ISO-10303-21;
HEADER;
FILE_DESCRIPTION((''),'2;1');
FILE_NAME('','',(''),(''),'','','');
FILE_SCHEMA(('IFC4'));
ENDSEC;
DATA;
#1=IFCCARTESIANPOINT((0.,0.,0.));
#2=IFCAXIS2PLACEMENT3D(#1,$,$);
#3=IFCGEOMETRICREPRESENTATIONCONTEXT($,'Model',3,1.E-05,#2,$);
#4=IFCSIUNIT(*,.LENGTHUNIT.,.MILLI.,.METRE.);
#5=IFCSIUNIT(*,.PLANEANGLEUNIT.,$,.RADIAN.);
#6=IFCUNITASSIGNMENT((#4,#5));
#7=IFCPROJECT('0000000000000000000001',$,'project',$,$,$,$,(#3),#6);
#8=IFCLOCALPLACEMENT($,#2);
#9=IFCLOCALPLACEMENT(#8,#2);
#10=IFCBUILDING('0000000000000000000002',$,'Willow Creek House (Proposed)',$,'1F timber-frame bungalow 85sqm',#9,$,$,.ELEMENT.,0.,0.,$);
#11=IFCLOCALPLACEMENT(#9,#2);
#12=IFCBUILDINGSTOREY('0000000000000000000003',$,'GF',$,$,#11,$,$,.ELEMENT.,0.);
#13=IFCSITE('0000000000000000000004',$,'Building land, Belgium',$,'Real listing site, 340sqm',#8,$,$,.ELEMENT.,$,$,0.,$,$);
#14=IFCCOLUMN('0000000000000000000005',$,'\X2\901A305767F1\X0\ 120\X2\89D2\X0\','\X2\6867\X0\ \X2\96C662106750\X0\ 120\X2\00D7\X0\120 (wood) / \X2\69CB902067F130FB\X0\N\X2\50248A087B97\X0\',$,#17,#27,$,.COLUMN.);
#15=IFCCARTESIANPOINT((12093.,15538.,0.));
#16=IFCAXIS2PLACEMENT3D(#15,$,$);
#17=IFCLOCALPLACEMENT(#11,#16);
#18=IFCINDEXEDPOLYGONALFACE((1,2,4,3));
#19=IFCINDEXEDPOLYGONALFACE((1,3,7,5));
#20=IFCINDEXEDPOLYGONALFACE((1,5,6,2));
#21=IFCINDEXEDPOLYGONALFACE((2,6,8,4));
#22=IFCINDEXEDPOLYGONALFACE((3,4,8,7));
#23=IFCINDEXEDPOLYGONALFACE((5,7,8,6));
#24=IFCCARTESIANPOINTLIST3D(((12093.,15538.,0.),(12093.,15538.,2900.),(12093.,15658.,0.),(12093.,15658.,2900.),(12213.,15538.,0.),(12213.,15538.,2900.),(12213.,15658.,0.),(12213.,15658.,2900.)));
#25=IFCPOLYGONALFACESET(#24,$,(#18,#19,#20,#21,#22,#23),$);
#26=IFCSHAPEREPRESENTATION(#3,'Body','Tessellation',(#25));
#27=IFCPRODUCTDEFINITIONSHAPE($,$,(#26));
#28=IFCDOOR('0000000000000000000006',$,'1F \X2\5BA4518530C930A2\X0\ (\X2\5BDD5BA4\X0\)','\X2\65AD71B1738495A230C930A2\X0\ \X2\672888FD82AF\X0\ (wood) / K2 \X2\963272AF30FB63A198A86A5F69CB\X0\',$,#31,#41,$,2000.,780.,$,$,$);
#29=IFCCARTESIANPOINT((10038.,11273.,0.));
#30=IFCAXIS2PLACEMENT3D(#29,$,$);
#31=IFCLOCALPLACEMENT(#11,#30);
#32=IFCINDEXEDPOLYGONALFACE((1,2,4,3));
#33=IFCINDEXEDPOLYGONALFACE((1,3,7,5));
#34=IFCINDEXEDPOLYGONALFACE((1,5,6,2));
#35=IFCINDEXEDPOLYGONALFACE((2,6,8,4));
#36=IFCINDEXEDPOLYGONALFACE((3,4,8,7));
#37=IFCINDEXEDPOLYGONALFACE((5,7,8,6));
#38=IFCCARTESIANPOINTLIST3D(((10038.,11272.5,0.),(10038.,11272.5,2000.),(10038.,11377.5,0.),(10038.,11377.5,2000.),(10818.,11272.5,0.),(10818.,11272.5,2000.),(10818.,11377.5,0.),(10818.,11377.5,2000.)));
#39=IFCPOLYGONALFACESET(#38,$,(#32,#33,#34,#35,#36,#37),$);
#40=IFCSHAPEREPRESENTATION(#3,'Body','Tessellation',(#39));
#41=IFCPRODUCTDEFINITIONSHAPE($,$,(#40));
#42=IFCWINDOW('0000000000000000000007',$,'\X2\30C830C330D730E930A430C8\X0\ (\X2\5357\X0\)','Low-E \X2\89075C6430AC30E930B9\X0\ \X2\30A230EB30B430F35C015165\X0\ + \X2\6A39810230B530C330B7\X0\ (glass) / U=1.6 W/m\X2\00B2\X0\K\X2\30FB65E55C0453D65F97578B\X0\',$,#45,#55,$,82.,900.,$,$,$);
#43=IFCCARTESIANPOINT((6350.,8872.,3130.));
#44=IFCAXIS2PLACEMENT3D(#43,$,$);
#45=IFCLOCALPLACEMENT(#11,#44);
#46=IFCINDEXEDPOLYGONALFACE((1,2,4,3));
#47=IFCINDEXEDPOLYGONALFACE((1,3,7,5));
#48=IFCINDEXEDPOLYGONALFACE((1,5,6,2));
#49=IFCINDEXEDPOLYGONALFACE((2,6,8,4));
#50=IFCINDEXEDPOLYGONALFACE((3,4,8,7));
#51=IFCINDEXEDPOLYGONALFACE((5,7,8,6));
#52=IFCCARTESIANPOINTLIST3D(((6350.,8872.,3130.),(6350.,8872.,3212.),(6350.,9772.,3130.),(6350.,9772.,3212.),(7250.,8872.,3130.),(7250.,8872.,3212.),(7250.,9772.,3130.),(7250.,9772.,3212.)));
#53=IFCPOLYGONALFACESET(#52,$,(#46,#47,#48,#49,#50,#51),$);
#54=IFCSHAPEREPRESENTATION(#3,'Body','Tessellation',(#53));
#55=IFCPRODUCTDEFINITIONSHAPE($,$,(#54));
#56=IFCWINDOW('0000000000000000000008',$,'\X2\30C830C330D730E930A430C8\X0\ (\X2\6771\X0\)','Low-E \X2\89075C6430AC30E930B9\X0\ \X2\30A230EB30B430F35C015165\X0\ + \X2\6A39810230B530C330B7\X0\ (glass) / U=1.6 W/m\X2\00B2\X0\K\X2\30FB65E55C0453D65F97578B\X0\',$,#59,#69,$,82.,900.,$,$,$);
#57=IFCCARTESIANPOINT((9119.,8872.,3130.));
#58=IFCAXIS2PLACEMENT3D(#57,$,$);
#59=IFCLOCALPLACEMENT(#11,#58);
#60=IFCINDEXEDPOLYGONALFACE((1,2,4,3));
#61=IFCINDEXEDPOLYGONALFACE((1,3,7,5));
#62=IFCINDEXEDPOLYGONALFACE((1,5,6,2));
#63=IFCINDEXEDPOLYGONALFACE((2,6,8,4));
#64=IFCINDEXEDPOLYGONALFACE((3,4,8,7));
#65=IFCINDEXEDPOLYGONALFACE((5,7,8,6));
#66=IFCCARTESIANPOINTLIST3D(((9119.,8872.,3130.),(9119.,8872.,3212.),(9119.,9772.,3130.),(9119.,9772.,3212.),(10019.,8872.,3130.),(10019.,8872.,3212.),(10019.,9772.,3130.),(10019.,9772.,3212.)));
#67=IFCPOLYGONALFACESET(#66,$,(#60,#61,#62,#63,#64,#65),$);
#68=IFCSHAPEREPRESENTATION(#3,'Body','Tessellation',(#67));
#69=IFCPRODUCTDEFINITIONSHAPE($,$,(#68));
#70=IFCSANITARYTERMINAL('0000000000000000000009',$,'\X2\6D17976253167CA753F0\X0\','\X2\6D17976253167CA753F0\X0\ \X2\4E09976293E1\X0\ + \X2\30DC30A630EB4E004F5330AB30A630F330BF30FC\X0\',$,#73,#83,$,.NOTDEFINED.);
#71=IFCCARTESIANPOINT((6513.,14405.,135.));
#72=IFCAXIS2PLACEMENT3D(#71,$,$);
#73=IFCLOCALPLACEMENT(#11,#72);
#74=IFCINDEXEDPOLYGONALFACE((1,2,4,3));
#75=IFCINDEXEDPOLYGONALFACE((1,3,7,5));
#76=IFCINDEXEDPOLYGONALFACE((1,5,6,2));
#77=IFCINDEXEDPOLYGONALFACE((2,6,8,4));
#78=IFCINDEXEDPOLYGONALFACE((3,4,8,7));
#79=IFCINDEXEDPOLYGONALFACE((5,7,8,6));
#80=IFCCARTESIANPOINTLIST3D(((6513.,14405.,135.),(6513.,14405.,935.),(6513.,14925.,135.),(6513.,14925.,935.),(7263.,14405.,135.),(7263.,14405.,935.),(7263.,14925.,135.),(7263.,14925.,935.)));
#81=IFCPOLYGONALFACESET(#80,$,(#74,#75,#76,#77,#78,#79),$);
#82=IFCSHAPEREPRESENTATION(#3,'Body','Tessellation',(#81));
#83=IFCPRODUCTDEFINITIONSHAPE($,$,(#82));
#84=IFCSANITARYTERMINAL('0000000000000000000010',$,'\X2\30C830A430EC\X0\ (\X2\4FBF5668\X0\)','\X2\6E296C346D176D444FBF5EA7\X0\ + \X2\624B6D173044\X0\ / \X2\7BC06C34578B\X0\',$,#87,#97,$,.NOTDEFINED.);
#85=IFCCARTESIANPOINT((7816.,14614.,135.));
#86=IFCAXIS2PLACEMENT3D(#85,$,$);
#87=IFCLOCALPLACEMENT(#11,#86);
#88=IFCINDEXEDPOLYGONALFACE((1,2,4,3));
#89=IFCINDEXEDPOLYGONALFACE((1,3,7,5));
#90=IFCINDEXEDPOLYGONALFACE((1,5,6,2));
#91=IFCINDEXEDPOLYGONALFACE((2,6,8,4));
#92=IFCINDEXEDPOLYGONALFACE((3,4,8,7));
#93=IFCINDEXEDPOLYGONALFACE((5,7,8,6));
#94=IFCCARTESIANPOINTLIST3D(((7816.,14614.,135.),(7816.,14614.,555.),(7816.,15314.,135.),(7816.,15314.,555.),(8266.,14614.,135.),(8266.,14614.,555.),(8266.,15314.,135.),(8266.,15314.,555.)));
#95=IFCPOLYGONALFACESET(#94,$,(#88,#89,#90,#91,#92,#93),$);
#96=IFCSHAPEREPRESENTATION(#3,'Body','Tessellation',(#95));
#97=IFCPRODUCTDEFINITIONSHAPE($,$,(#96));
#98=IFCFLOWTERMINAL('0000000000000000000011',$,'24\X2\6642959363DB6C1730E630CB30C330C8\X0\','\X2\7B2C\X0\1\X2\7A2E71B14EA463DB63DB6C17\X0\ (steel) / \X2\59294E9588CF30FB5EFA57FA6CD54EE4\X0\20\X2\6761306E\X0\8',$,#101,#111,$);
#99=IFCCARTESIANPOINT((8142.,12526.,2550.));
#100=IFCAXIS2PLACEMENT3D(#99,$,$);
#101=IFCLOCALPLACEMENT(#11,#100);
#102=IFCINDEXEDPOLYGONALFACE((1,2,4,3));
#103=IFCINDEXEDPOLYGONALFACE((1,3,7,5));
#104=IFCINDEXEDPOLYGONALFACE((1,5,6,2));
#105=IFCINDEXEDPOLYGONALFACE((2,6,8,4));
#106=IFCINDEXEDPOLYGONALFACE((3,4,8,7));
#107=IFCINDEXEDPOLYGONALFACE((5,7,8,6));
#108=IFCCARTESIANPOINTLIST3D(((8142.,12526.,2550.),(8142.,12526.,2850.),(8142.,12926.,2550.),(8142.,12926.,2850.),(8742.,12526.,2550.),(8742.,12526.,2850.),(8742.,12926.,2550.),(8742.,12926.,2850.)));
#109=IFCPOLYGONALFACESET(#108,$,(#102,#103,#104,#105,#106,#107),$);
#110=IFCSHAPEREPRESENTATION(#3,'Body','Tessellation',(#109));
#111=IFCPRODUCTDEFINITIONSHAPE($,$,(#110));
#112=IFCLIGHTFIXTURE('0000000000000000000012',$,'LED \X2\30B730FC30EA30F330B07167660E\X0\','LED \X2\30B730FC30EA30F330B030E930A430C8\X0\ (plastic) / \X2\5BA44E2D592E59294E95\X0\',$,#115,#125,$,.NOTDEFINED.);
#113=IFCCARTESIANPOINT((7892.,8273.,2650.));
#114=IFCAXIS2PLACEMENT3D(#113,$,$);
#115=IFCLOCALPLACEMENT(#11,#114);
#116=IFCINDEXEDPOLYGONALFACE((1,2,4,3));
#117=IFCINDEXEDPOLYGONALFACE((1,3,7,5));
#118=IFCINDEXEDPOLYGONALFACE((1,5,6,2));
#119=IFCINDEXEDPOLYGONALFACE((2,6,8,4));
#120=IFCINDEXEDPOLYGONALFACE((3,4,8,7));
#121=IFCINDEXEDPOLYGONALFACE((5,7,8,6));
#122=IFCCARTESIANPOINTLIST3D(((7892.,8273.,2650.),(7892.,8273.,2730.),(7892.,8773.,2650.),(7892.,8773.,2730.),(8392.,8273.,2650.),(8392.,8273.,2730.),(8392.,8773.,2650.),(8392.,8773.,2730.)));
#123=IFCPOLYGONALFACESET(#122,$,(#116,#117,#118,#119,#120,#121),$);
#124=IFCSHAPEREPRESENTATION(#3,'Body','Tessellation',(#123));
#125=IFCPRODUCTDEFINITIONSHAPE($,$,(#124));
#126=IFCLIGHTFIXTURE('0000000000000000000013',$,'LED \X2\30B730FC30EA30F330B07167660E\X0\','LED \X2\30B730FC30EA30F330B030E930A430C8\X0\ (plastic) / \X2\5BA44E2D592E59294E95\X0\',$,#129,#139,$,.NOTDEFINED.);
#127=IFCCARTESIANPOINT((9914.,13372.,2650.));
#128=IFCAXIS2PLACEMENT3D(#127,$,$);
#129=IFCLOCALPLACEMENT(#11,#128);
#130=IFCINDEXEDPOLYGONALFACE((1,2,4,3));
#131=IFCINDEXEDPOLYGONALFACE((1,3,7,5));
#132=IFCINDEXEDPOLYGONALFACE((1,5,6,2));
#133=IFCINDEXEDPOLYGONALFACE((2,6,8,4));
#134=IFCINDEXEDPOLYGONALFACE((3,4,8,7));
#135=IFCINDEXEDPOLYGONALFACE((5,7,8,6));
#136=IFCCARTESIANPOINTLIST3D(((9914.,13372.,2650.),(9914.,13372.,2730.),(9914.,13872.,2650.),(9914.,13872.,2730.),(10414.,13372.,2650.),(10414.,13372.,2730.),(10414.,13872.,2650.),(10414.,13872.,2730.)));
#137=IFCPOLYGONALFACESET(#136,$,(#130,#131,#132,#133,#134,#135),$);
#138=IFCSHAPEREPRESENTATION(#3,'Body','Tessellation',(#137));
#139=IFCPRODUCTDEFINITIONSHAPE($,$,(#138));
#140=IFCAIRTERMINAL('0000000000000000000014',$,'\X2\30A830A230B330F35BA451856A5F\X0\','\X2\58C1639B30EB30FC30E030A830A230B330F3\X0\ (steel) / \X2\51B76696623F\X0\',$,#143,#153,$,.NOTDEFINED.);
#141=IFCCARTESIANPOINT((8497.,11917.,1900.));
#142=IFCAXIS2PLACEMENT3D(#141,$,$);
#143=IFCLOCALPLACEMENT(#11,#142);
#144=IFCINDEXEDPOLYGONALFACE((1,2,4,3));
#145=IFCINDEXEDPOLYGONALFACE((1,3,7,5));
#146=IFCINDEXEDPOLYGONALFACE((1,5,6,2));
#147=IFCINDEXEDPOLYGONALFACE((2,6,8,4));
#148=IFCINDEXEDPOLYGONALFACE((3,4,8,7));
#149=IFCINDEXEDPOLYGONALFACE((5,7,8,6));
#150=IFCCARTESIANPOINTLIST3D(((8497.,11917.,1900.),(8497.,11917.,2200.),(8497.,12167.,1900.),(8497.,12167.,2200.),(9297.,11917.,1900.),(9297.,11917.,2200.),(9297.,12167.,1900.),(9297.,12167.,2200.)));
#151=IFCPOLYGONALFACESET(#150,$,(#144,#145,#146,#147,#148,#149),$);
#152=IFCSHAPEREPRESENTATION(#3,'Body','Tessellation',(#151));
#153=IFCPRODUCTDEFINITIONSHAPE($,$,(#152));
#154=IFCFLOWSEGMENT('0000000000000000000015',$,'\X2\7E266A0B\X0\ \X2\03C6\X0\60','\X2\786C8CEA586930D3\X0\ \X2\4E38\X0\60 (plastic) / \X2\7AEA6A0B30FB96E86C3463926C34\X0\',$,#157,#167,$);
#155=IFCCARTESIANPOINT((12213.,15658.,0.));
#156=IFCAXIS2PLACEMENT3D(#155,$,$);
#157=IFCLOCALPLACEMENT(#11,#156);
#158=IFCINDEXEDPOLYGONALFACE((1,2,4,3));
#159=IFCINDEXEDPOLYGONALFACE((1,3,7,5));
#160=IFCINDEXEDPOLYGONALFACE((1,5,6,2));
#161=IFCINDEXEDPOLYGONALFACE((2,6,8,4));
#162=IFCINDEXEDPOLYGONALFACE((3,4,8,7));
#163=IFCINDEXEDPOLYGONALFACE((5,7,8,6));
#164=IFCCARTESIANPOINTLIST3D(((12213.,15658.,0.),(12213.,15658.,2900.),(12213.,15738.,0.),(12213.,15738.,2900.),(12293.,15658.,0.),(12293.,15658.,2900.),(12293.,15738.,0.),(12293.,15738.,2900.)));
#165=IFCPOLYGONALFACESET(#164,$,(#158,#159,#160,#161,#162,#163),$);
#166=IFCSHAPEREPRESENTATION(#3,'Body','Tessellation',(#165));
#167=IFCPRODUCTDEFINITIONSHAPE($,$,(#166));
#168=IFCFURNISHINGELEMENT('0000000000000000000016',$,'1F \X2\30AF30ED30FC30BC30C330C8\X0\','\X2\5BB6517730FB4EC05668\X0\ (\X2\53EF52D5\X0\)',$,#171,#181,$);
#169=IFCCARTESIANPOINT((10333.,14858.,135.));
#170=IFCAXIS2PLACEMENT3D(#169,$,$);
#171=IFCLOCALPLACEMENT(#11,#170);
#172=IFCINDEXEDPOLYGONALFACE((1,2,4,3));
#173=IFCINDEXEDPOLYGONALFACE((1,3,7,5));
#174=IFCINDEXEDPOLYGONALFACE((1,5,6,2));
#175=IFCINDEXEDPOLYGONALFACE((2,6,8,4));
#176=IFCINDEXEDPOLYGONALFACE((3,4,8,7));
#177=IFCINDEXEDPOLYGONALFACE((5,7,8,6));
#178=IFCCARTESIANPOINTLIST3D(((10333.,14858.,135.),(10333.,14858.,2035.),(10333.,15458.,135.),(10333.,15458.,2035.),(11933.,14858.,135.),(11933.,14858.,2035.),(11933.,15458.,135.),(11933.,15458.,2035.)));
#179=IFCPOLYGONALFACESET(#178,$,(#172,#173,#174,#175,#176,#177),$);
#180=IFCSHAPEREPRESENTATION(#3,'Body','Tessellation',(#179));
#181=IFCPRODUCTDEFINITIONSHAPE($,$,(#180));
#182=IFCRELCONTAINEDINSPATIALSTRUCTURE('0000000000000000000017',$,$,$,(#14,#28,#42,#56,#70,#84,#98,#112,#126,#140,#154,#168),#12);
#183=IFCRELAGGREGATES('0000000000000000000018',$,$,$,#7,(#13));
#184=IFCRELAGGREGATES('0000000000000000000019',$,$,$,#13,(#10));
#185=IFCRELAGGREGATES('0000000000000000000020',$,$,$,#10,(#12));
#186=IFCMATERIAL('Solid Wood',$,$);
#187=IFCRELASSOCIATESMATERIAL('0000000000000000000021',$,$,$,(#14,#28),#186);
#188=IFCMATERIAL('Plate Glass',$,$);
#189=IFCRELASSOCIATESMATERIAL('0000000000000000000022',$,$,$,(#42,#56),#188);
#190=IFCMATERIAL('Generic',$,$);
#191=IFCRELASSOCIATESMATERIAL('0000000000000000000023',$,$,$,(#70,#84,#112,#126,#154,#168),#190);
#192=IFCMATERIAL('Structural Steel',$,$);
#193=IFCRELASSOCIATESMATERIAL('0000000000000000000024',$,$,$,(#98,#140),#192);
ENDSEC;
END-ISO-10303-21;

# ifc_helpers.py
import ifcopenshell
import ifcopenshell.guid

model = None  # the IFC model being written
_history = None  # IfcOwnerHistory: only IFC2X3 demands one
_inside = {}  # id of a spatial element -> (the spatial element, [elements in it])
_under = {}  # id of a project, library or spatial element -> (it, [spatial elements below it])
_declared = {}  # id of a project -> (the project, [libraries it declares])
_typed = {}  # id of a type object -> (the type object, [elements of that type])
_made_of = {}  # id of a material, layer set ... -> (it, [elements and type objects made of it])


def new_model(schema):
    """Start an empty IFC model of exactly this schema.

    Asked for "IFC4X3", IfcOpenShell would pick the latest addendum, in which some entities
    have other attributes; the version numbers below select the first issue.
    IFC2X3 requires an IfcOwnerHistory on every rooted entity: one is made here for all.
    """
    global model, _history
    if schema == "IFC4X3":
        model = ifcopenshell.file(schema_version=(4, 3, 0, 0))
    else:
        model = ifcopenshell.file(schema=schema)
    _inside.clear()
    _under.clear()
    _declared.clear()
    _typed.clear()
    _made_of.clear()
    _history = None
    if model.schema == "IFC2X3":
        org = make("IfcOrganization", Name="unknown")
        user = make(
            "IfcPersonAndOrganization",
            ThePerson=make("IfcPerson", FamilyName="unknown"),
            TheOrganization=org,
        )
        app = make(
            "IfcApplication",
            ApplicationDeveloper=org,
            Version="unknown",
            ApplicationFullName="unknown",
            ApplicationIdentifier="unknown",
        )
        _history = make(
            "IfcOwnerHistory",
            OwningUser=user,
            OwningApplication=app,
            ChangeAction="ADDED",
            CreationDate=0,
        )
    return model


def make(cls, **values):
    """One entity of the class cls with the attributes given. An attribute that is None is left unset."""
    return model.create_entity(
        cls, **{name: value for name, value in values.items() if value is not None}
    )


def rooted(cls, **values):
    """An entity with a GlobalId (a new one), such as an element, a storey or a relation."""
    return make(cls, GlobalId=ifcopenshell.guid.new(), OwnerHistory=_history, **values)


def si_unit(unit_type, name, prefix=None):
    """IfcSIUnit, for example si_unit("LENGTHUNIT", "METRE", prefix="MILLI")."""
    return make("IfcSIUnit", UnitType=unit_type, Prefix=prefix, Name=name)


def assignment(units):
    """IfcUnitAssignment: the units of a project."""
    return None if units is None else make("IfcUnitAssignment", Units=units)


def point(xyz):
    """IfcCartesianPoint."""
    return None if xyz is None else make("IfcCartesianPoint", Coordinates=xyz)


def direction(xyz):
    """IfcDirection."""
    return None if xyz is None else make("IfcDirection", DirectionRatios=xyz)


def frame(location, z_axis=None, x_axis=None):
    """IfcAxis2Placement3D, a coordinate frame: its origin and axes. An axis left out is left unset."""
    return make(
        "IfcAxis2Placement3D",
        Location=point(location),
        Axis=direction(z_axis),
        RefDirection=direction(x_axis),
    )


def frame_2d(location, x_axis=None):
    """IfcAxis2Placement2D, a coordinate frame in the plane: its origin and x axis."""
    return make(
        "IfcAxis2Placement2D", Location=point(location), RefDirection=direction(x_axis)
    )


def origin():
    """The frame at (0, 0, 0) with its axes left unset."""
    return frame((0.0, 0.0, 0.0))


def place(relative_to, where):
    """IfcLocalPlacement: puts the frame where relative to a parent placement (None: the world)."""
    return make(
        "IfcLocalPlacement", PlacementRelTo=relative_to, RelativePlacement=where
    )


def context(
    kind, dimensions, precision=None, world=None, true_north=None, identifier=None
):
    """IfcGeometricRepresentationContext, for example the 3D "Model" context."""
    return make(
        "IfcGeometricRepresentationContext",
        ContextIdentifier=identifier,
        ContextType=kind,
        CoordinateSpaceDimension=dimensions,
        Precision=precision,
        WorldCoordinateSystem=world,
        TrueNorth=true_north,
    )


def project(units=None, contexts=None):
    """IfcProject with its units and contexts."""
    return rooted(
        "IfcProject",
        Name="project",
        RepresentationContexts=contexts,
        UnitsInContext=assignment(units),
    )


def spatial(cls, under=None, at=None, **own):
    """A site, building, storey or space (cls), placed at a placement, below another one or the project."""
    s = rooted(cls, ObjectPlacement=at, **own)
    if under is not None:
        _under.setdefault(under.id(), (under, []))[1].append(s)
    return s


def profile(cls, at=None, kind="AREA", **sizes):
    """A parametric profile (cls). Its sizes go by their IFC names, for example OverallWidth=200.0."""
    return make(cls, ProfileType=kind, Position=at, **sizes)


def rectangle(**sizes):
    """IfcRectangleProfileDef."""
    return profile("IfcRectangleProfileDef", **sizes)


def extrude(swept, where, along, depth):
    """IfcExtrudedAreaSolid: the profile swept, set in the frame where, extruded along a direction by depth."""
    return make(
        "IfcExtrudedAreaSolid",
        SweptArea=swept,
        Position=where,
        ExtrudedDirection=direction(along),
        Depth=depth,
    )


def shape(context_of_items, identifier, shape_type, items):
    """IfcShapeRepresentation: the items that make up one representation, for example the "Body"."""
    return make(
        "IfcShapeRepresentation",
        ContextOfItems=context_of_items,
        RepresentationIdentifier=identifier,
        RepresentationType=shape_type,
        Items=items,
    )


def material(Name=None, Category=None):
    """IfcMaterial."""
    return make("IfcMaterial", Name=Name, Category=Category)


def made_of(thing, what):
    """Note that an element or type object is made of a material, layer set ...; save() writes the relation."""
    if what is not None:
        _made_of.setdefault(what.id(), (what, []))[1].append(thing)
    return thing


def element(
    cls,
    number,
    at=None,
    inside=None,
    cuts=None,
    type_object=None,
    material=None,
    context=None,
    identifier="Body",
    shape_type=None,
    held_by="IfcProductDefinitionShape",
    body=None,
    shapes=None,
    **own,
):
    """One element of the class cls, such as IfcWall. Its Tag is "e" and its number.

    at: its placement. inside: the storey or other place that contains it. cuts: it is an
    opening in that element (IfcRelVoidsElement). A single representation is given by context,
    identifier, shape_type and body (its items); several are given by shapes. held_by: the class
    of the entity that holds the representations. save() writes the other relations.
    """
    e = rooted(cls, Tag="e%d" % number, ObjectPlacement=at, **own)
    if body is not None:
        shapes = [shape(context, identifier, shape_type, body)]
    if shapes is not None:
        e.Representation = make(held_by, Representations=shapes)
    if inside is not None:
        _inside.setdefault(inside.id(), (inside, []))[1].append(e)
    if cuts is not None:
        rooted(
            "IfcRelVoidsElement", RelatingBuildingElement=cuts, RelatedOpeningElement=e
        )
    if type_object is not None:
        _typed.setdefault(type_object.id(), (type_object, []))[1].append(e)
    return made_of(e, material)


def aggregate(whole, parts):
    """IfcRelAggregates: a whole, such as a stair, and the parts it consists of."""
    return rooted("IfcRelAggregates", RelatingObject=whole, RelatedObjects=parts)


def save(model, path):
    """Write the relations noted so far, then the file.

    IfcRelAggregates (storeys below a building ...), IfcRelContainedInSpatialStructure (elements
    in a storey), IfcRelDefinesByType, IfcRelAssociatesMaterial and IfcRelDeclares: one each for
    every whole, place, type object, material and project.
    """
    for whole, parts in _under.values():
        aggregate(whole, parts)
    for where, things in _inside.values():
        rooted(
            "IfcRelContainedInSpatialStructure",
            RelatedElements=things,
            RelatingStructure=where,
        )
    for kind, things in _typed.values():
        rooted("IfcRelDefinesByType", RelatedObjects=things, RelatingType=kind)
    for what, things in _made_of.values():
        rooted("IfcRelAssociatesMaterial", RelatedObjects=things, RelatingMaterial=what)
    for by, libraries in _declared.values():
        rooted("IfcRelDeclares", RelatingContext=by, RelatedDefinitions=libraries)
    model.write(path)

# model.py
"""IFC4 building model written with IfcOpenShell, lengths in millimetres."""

from ifc_helpers import new_model, si_unit, frame, frame_2d, origin, place, context, project, spatial, rectangle, extrude, material, element, save


model = new_model("IFC4")

# Units and contexts
model_context = context("Model", 3, precision=1e-05, world=origin())
ifc_project = project(units=[si_unit("LENGTHUNIT", "METRE", prefix="MILLI"), si_unit("PLANEANGLEUNIT", "RADIAN")], contexts=[model_context])

# Site, building, storey
site_placement = place(None, origin())
site = spatial("IfcSite", under=ifc_project, at=site_placement, Name="Building land, Belgium", ObjectType="Real listing site, 340sqm", CompositionType="ELEMENT", RefElevation=0.0)
building_placement = place(site_placement, origin())
building = spatial("IfcBuilding", under=site, at=building_placement, Name="Willow Creek House (Proposed)", ObjectType="1F timber-frame bungalow 85sqm", CompositionType="ELEMENT", ElevationOfRefHeight=0.0, ElevationOfTerrain=0.0)
storey_placement = place(building_placement, origin())
storey = spatial("IfcBuildingStorey", under=building, at=storey_placement, Name="GF", CompositionType="ELEMENT", Elevation=0.0)

# Column
ifc_material_1 = material(Name="Solid Wood")
column_1_placement = place(storey_placement, frame((12093.0, 15538.0, 0.0)))
element("IfcColumn", 1, at=column_1_placement, inside=storey, material=ifc_material_1, Name="通し柱 120角", Description="桧 集成材 120×120 (wood) / 構造柱・N値計算", PredefinedType="COLUMN", context=model_context, shape_type="SweptSolid", body=[
    extrude(rectangle(XDim=120.0, YDim=120.0, at=frame_2d((60.0, 60.0))), frame((12093.0, 15538.0, 0.0)), (0.0, 0.0, 1.0), 2900.0),
])

# Door
door_placement = place(storey_placement, frame((10038.0, 11273.0, 0.0)))
element("IfcDoor", 2, at=door_placement, inside=storey, material=ifc_material_1, Name="1F 室内ドア (寝室)", Description="断熱玄関ドア 木製芯 (wood) / K2 防犯・採風機構", OverallHeight=2000.0, OverallWidth=780.0, context=model_context, shape_type="SweptSolid", body=[
    extrude(rectangle(XDim=780.0, YDim=105.0, at=frame_2d((390.0, 52.0))), frame((10038.0, 11273.0, 0.0)), (0.0, 0.0, 1.0), 2000.0),
])

# Windows
ifc_material_2 = material(Name="Plate Glass")
window_1_placement = place(storey_placement, frame((6350.0, 8872.0, 3130.0)))
element("IfcWindow", 3, at=window_1_placement, inside=storey, material=ifc_material_2, Name="トップライト (南)", Description="Low-E 複層ガラス アルゴン封入 + 樹脂サッシ (glass) / U=1.6 W/m²K・日射取得型", OverallHeight=82.0, OverallWidth=900.0, context=model_context, shape_type="SweptSolid", body=[
    extrude(rectangle(XDim=900.0, YDim=900.0, at=frame_2d((450.0, 450.0))), frame((6350.0, 8872.0, 3130.0)), (0.0, 0.0, 1.0), 82.0),
])
window_2_placement = place(storey_placement, frame((9119.0, 8872.0, 3130.0)))
element("IfcWindow", 4, at=window_2_placement, inside=storey, material=ifc_material_2, Name="トップライト (東)", Description="Low-E 複層ガラス アルゴン封入 + 樹脂サッシ (glass) / U=1.6 W/m²K・日射取得型", OverallHeight=82.0, OverallWidth=900.0, context=model_context, shape_type="SweptSolid", body=[
    extrude(rectangle(XDim=900.0, YDim=900.0, at=frame_2d((450.0, 450.0))), frame((9119.0, 8872.0, 3130.0)), (0.0, 0.0, 1.0), 82.0),
])

# Sanitary terminals
ifc_material_3 = material(Name="Generic")
sanitary_terminal_1_placement = place(storey_placement, frame((6513.0, 14405.0, 135.0)))
element("IfcSanitaryTerminal", 5, at=sanitary_terminal_1_placement, inside=storey, material=ifc_material_3, Name="洗面化粧台", Description="洗面化粧台 三面鏡 + ボウル一体カウンター", PredefinedType="NOTDEFINED", context=model_context, shape_type="SweptSolid", body=[
    extrude(rectangle(XDim=750.0, YDim=520.0, at=frame_2d((375.0, 260.0))), frame((6513.0, 14405.0, 135.0)), (0.0, 0.0, 1.0), 800.0),
])
sanitary_terminal_2_placement = place(storey_placement, frame((7816.0, 14614.0, 135.0)))
element("IfcSanitaryTerminal", 6, at=sanitary_terminal_2_placement, inside=storey, material=ifc_material_3, Name="トイレ (便器)", Description="温水洗浄便座 + 手洗い / 節水型", PredefinedType="NOTDEFINED", context=model_context, shape_type="SweptSolid", body=[
    extrude(rectangle(XDim=450.0, YDim=700.0, at=frame_2d((225.0, 350.0))), frame((7816.0, 14614.0, 135.0)), (0.0, 0.0, 1.0), 420.0),
])

# Flow terminal
ifc_material_4 = material(Name="Structural Steel")
flow_terminal_placement = place(storey_placement, frame((8142.0, 12526.0, 2550.0)))
element("IfcFlowTerminal", 7, at=flow_terminal_placement, inside=storey, material=ifc_material_4, Name="24時間換気ユニット", Description="第1種熱交換換気 (steel) / 天井裏・建基法令20条の8", context=model_context, shape_type="SweptSolid", body=[
    extrude(rectangle(XDim=600.0, YDim=400.0, at=frame_2d((300.0, 200.0))), frame((8142.0, 12526.0, 2550.0)), (0.0, 0.0, 1.0), 300.0),
])

# Light fixtures
light_fixture_1_placement = place(storey_placement, frame((7892.0, 8273.0, 2650.0)))
element("IfcLightFixture", 8, at=light_fixture_1_placement, inside=storey, material=ifc_material_3, Name="LED シーリング照明", Description="LED シーリングライト (plastic) / 室中央天井", PredefinedType="NOTDEFINED", context=model_context, shape_type="SweptSolid", body=[
    extrude(rectangle(XDim=500.0, YDim=500.0, at=frame_2d((250.0, 250.0))), frame((7892.0, 8273.0, 2650.0)), (0.0, 0.0, 1.0), 80.0),
])
light_fixture_2_placement = place(storey_placement, frame((9914.0, 13372.0, 2650.0)))
element("IfcLightFixture", 9, at=light_fixture_2_placement, inside=storey, material=ifc_material_3, Name="LED シーリング照明", Description="LED シーリングライト (plastic) / 室中央天井", PredefinedType="NOTDEFINED", context=model_context, shape_type="SweptSolid", body=[
    extrude(rectangle(XDim=500.0, YDim=500.0, at=frame_2d((250.0, 250.0))), frame((9914.0, 13372.0, 2650.0)), (0.0, 0.0, 1.0), 80.0),
])

# Air terminal
air_terminal_placement = place(storey_placement, frame((8497.0, 11917.0, 1900.0)))
element("IfcAirTerminal", 10, at=air_terminal_placement, inside=storey, material=ifc_material_4, Name="エアコン室内機", Description="壁掛ルームエアコン (steel) / 冷暖房", PredefinedType="NOTDEFINED", context=model_context, shape_type="SweptSolid", body=[
    extrude(rectangle(XDim=800.0, YDim=250.0, at=frame_2d((400.0, 125.0))), frame((8497.0, 11917.0, 1900.0)), (0.0, 0.0, 1.0), 300.0),
])

# Flow segment
flow_segment_placement = place(storey_placement, frame((12213.0, 15658.0, 0.0)))
element("IfcFlowSegment", 11, at=flow_segment_placement, inside=storey, material=ifc_material_3, Name="縦樋 φ60", Description="硬質塩ビ 丸60 (plastic) / 竪樋・雨水排水", context=model_context, shape_type="SweptSolid", body=[
    extrude(rectangle(XDim=80.0, YDim=80.0, at=frame_2d((40.0, 40.0))), frame((12213.0, 15658.0, 0.0)), (0.0, 0.0, 1.0), 2900.0),
])

# Furnishing element
furnishing_placement = place(storey_placement, frame((10333.0, 14858.0, 135.0)))
element("IfcFurnishingElement", 12, at=furnishing_placement, inside=storey, material=ifc_material_3, Name="1F クローゼット", Description="家具・什器 (可動)", context=model_context, shape_type="SweptSolid", body=[
    extrude(rectangle(XDim=1600.0, YDim=600.0, at=frame_2d((800.0, 300.0))), frame((10333.0, 14858.0, 135.0)), (0.0, 0.0, 1.0), 1900.0),
])

save(model, "model.ifc")
